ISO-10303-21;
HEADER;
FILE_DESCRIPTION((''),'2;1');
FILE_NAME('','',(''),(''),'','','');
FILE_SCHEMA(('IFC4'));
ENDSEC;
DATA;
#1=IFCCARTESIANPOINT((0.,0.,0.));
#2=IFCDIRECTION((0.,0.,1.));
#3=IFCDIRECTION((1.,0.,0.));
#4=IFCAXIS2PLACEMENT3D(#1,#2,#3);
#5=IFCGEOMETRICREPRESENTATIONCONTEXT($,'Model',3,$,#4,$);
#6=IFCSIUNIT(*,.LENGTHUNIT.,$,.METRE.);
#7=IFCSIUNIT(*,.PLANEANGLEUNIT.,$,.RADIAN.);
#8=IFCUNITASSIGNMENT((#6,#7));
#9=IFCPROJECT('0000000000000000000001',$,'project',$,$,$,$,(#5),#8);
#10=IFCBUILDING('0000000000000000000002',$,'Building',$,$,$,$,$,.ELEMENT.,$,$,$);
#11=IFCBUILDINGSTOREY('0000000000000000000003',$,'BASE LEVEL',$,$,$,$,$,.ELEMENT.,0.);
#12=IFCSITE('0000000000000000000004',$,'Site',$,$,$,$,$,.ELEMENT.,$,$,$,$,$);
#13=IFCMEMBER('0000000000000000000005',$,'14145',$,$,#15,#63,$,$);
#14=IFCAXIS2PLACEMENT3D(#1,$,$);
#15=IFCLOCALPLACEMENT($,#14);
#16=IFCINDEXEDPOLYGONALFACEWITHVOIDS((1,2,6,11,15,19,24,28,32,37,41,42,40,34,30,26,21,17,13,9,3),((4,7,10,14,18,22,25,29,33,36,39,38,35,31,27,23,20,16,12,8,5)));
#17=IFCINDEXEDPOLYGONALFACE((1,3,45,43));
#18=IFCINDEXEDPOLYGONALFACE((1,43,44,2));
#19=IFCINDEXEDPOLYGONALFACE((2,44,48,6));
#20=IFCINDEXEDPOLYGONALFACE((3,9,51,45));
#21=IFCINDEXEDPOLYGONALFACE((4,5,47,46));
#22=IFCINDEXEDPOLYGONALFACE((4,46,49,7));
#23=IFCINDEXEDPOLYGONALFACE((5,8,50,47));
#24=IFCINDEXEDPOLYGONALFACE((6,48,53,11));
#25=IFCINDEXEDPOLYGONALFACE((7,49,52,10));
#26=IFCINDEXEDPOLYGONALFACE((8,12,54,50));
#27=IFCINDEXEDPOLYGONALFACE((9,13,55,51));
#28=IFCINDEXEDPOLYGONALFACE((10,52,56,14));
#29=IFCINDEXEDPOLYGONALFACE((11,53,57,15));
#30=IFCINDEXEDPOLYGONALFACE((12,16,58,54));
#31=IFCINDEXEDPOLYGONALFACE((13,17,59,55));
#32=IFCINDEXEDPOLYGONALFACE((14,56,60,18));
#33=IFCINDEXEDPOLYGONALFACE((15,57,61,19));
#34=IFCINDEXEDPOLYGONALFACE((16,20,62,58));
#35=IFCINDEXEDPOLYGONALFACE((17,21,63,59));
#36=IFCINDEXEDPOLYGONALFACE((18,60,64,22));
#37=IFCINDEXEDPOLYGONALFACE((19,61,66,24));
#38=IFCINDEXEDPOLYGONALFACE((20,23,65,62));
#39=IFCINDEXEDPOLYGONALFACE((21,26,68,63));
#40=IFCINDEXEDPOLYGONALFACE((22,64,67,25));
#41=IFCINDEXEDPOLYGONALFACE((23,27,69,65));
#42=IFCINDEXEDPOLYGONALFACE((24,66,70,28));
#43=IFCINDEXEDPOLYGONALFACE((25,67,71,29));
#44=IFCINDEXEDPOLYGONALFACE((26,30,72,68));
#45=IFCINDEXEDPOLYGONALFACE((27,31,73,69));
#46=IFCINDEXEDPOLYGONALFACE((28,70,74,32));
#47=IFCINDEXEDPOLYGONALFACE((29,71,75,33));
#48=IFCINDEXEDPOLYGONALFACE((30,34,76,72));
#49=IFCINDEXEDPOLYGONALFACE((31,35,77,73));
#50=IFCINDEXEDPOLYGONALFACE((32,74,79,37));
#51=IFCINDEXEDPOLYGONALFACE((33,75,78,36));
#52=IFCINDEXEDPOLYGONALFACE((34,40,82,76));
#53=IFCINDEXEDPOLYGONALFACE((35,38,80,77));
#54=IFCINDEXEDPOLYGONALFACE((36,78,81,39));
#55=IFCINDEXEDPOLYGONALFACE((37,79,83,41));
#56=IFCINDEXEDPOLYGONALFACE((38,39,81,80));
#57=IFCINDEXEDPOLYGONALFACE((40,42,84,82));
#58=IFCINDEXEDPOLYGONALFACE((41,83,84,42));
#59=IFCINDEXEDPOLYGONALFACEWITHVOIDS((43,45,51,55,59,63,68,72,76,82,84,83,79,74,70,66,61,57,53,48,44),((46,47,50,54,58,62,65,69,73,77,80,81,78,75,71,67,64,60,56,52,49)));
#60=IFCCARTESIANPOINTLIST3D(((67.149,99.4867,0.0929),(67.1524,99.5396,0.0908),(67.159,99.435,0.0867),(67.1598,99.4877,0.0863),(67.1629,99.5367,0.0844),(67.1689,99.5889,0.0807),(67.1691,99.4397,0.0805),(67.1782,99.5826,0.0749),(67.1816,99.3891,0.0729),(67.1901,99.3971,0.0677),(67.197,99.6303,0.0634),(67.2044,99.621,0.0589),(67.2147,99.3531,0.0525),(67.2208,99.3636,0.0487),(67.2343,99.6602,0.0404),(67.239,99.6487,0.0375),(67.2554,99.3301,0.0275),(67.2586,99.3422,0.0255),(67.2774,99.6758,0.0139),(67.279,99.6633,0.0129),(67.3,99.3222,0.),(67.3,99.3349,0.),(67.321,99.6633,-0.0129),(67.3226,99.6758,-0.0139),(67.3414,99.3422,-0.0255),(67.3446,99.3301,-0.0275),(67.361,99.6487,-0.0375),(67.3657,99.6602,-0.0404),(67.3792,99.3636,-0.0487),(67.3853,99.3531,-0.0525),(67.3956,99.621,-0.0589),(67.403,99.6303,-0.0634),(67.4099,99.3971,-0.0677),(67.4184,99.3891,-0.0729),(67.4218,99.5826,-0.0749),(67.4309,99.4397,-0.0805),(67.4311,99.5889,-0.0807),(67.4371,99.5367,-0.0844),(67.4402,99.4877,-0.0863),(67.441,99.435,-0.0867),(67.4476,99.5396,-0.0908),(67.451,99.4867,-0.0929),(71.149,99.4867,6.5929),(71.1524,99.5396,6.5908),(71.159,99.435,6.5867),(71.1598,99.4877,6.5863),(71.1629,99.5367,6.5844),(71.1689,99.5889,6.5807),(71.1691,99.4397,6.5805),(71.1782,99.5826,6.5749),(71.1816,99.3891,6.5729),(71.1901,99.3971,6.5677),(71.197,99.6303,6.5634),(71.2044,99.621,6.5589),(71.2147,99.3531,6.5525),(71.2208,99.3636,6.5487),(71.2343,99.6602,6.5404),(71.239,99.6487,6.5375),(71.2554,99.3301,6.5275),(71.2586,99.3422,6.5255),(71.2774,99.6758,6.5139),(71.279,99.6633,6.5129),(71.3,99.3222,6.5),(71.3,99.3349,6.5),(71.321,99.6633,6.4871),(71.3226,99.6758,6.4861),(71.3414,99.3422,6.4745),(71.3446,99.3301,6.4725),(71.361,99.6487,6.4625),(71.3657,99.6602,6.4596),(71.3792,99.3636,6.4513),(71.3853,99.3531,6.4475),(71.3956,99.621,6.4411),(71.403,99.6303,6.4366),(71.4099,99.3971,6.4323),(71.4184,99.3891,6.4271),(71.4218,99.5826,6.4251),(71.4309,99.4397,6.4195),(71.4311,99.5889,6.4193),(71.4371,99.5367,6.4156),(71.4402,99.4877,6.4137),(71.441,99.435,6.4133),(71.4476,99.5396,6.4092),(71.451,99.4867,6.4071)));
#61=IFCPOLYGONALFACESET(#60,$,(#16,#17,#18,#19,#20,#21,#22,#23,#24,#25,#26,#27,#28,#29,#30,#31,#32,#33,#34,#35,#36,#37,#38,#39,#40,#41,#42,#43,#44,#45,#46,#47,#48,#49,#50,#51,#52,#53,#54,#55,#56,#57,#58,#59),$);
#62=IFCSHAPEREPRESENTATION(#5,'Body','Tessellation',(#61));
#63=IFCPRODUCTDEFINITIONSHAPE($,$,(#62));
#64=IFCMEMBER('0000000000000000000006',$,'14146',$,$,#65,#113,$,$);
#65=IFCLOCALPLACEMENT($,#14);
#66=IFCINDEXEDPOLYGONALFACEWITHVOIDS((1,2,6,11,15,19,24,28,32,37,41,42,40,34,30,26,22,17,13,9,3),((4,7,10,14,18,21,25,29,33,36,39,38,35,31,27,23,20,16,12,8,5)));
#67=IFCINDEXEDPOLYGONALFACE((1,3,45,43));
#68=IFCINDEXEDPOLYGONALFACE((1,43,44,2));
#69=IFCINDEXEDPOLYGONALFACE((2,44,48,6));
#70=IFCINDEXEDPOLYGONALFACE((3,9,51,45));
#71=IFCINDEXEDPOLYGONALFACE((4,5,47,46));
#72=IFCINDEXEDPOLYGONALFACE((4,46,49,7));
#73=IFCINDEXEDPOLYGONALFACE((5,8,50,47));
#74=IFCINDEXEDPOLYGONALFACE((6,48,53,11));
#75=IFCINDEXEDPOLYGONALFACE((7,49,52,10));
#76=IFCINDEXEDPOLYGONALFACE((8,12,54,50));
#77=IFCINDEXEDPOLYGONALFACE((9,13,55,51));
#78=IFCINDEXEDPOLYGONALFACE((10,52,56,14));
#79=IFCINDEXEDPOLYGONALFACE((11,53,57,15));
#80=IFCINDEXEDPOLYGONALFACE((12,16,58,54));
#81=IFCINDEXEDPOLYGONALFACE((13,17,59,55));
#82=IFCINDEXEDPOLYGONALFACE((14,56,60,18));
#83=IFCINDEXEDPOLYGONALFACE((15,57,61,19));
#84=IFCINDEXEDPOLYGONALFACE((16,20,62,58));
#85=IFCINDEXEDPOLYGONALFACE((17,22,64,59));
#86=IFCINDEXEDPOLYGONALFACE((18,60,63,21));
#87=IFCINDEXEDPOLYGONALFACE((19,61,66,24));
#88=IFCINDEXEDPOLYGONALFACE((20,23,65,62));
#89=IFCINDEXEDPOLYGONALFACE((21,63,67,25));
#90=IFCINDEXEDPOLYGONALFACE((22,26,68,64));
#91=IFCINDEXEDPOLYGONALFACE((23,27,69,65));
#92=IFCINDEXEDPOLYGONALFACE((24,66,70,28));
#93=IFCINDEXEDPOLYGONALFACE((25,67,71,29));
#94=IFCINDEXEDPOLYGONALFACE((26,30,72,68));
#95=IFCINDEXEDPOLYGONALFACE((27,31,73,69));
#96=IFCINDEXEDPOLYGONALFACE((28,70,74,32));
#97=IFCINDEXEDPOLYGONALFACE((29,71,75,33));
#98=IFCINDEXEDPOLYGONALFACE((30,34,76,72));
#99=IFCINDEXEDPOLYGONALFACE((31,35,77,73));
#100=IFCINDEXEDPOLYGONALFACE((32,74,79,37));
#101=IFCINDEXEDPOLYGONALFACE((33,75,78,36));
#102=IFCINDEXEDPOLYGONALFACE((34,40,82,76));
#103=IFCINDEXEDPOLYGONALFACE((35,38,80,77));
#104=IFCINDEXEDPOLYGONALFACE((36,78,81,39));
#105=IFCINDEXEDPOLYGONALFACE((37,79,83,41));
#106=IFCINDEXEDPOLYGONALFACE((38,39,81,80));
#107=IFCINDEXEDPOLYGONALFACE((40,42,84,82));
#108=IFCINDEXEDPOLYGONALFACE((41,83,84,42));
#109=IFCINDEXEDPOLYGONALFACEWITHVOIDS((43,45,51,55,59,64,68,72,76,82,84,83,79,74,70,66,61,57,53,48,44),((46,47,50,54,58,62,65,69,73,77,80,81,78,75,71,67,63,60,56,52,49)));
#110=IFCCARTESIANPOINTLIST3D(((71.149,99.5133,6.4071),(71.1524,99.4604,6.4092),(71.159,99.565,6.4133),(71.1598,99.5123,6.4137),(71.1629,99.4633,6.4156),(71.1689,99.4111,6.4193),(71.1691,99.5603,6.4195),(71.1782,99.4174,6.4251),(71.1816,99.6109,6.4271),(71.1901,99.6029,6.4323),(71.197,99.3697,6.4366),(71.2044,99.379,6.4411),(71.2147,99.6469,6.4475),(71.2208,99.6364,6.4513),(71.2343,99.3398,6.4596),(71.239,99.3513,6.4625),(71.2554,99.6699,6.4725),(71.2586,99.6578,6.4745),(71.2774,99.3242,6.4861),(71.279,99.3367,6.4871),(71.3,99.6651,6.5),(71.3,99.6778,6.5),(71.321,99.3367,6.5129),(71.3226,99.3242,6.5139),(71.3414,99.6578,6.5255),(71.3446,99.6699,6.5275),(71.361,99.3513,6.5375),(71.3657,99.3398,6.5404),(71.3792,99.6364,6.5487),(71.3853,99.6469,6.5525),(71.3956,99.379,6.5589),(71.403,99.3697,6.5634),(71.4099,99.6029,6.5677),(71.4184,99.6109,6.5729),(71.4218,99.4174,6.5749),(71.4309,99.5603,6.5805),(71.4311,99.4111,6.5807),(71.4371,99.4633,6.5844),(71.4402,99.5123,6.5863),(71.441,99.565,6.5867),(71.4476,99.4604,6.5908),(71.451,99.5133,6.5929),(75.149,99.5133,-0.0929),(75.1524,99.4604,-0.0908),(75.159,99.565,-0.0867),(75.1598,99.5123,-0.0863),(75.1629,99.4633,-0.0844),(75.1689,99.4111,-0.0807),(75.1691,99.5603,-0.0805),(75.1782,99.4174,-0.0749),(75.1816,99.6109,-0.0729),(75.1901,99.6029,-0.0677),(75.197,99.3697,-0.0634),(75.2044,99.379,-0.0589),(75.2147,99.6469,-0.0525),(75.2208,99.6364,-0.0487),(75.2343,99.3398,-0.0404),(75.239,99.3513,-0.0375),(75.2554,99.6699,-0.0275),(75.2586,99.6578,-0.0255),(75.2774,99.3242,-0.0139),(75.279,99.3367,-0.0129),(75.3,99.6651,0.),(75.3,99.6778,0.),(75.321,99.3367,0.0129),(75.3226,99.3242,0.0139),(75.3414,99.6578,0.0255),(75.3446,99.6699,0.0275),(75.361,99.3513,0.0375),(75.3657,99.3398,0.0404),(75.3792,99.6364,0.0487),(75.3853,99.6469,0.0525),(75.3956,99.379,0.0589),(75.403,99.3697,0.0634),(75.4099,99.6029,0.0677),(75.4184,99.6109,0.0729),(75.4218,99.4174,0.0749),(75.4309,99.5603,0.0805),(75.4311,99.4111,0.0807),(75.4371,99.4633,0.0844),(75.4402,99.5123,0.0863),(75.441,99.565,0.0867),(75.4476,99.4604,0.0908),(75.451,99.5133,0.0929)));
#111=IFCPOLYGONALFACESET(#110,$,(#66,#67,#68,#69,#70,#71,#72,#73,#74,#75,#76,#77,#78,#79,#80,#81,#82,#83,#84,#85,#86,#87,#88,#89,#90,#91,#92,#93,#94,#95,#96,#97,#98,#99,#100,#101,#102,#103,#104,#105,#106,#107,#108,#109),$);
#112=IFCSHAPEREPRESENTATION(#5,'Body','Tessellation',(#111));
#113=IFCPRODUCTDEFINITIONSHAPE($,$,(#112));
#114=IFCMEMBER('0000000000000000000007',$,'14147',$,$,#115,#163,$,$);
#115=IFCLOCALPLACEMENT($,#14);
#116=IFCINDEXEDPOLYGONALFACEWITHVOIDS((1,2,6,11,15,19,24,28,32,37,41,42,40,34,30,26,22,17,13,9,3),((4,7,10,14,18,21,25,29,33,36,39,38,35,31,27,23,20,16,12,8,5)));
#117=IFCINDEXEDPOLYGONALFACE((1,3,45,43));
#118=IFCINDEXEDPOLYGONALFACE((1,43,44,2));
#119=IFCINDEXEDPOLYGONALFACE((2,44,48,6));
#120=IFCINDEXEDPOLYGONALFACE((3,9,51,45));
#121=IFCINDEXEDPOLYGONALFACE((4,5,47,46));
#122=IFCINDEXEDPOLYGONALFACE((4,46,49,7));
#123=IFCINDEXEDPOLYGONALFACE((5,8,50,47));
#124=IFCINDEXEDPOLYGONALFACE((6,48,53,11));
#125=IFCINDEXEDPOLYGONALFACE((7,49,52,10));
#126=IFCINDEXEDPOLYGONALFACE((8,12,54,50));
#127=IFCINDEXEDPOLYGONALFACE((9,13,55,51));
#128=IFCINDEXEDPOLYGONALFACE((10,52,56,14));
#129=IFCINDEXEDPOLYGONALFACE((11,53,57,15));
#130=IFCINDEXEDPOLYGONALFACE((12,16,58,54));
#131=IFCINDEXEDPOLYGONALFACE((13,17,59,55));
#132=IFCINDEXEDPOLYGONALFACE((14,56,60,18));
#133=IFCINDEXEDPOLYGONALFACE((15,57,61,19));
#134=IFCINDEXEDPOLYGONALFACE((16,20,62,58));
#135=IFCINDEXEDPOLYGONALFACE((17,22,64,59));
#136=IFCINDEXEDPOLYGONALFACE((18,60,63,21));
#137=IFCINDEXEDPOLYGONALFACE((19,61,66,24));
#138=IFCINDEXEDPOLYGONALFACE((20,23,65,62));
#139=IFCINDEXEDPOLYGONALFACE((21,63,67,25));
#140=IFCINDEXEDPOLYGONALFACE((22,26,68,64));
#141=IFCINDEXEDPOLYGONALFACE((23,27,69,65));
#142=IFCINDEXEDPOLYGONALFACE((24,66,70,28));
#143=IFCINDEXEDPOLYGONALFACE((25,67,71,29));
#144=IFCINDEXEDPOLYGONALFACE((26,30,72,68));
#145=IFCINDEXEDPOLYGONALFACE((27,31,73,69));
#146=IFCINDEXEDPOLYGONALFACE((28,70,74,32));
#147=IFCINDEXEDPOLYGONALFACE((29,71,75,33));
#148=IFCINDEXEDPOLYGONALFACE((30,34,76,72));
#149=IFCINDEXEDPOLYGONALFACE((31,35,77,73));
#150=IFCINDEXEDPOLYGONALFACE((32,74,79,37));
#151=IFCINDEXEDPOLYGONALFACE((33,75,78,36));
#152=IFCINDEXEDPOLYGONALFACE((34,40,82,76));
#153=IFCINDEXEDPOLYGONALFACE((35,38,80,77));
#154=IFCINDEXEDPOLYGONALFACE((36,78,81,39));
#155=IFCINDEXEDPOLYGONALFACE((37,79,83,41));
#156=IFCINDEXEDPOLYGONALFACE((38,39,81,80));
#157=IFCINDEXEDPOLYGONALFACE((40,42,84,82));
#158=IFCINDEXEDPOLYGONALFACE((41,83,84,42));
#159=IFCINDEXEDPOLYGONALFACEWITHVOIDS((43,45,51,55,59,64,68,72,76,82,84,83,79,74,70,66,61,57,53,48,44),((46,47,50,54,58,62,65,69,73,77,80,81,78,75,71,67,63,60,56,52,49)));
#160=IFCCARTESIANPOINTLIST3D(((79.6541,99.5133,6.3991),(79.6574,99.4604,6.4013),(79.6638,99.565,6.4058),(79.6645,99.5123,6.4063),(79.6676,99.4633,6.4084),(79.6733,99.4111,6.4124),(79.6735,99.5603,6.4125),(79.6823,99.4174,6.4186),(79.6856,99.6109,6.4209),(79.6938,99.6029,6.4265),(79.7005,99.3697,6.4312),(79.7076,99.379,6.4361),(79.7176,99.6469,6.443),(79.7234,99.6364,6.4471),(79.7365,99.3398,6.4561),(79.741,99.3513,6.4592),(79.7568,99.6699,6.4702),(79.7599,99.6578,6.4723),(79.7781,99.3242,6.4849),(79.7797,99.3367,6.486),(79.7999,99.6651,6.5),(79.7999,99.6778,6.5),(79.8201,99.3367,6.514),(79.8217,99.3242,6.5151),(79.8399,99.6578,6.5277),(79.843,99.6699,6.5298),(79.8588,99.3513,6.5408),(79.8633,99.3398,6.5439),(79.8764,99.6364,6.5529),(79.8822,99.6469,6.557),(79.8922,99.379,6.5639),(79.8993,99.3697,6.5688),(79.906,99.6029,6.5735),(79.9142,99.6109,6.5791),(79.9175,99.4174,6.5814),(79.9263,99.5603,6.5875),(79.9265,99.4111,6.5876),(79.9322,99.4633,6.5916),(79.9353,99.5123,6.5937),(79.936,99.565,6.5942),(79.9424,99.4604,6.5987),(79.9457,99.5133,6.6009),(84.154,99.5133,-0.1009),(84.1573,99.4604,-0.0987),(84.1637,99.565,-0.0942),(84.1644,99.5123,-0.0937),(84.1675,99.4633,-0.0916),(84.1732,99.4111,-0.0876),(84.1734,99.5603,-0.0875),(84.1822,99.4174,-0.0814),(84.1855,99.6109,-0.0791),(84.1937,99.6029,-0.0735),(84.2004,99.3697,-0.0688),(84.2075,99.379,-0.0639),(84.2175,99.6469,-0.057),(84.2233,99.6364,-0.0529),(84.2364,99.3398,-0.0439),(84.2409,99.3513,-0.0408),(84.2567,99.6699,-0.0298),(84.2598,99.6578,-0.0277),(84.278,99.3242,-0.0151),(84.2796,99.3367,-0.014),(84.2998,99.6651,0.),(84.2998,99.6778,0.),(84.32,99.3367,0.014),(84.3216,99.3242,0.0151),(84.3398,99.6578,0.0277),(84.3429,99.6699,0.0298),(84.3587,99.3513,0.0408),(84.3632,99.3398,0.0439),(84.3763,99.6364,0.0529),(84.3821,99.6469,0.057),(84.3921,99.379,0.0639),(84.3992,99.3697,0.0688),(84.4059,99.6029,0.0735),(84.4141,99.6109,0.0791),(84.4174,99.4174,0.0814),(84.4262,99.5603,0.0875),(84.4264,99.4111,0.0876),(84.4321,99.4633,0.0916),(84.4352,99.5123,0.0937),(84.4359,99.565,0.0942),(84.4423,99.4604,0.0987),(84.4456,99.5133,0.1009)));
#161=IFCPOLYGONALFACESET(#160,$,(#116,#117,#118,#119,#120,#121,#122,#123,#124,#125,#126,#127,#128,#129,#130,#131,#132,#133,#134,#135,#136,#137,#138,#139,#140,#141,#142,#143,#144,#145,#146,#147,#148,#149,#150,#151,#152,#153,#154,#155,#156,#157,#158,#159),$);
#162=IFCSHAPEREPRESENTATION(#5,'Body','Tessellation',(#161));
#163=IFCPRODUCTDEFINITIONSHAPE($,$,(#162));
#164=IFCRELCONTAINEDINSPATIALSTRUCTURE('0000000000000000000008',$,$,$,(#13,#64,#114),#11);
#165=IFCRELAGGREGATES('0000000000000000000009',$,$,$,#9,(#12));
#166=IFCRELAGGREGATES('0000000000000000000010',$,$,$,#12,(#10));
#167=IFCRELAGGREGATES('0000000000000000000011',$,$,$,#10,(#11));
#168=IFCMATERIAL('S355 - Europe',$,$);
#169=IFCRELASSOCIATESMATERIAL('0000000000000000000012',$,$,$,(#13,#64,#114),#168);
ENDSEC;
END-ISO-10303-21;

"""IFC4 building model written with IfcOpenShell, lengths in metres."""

from ifc_helpers import new_model, si_unit, frame, origin_with_axes, origin_2d_with_axis, place, context, project, spatial, hollow_circle, extrude, material, material_profile, profile_set, profile_usage, element, save


model = new_model("IFC4")

# Units and contexts
model_context = context("Model", 3, world=origin_with_axes())
ifc_project = project(units=[si_unit("LENGTHUNIT", "METRE"), si_unit("PLANEANGLEUNIT", "RADIAN")], contexts=[model_context])

# Site, building, storey
site = spatial("IfcSite", under=ifc_project, Name="Site", CompositionType="ELEMENT")
building = spatial("IfcBuilding", under=site, Name="Building", CompositionType="ELEMENT")
storey = spatial("IfcBuildingStorey", under=building, Name="BASE LEVEL", CompositionType="ELEMENT", Elevation=0.0)

# Shared definitions
ifc_material = material(Name="S355 - Europe")

# Members
ifc_material_profile_1 = material_profile(ifc_material, hollow_circle(Radius=0.1778, WallThickness=0.0127, at=origin_2d_with_axis()))
ifc_profile_set_1 = profile_set([ifc_material_profile_1])
ifc_profile_usage_1 = profile_usage(ifc_profile_set_1, cardinal=10)
member_1_placement = place(None, frame((71.3, 99.5, 6.5), z_axis=(-0.524097, 0.0, -0.851658), x_axis=(0.0, -1.0, 0.0)))
element("IfcMember", 1, at=member_1_placement, inside=storey, material=ifc_profile_usage_1, Name="14145", context=model_context, shape_type="SweptSolid", body=[
    extrude(hollow_circle(Radius=0.1778, WallThickness=0.0127, at=origin_2d_with_axis()), origin_with_axes(), (0.0, 0.0, 1.0), 7.6322),
])
ifc_material_profile_2 = material_profile(ifc_material, hollow_circle(Radius=0.1778, WallThickness=0.0127, at=origin_2d_with_axis()))
ifc_profile_set_2 = profile_set([ifc_material_profile_2])
ifc_profile_usage_2 = profile_usage(ifc_profile_set_2, cardinal=10)
member_2_placement = place(None, frame((71.3, 99.5, 6.5), z_axis=(0.524097, 0.0, -0.851658), x_axis=(0.0, 1.0, 0.0)))
element("IfcMember", 2, at=member_2_placement, inside=storey, material=ifc_profile_usage_2, Name="14146", context=model_context, shape_type="SweptSolid", body=[
    extrude(hollow_circle(Radius=0.1778, WallThickness=0.0127, at=origin_2d_with_axis()), origin_with_axes(), (0.0, 0.0, 1.0), 7.6322),
])
ifc_material_profile_3 = material_profile(ifc_material, hollow_circle(Radius=0.1778, WallThickness=0.0127, at=origin_2d_with_axis()))
ifc_profile_set_3 = profile_set([ifc_material_profile_3])
ifc_profile_usage_3 = profile_usage(ifc_profile_set_3, cardinal=10)
member_3_placement = place(None, frame((79.7999, 99.5, 6.5), z_axis=(0.569201, 0.0, -0.822198), x_axis=(0.0, 1.0, 0.0)))
element("IfcMember", 3, at=member_3_placement, inside=storey, material=ifc_profile_usage_3, Name="14147", context=model_context, shape_type="SweptSolid", body=[
    extrude(hollow_circle(Radius=0.1778, WallThickness=0.0127, at=origin_2d_with_axis()), origin_with_axes(), (0.0, 0.0, 1.0), 7.9056),
])

save(model, "model.ifc")
